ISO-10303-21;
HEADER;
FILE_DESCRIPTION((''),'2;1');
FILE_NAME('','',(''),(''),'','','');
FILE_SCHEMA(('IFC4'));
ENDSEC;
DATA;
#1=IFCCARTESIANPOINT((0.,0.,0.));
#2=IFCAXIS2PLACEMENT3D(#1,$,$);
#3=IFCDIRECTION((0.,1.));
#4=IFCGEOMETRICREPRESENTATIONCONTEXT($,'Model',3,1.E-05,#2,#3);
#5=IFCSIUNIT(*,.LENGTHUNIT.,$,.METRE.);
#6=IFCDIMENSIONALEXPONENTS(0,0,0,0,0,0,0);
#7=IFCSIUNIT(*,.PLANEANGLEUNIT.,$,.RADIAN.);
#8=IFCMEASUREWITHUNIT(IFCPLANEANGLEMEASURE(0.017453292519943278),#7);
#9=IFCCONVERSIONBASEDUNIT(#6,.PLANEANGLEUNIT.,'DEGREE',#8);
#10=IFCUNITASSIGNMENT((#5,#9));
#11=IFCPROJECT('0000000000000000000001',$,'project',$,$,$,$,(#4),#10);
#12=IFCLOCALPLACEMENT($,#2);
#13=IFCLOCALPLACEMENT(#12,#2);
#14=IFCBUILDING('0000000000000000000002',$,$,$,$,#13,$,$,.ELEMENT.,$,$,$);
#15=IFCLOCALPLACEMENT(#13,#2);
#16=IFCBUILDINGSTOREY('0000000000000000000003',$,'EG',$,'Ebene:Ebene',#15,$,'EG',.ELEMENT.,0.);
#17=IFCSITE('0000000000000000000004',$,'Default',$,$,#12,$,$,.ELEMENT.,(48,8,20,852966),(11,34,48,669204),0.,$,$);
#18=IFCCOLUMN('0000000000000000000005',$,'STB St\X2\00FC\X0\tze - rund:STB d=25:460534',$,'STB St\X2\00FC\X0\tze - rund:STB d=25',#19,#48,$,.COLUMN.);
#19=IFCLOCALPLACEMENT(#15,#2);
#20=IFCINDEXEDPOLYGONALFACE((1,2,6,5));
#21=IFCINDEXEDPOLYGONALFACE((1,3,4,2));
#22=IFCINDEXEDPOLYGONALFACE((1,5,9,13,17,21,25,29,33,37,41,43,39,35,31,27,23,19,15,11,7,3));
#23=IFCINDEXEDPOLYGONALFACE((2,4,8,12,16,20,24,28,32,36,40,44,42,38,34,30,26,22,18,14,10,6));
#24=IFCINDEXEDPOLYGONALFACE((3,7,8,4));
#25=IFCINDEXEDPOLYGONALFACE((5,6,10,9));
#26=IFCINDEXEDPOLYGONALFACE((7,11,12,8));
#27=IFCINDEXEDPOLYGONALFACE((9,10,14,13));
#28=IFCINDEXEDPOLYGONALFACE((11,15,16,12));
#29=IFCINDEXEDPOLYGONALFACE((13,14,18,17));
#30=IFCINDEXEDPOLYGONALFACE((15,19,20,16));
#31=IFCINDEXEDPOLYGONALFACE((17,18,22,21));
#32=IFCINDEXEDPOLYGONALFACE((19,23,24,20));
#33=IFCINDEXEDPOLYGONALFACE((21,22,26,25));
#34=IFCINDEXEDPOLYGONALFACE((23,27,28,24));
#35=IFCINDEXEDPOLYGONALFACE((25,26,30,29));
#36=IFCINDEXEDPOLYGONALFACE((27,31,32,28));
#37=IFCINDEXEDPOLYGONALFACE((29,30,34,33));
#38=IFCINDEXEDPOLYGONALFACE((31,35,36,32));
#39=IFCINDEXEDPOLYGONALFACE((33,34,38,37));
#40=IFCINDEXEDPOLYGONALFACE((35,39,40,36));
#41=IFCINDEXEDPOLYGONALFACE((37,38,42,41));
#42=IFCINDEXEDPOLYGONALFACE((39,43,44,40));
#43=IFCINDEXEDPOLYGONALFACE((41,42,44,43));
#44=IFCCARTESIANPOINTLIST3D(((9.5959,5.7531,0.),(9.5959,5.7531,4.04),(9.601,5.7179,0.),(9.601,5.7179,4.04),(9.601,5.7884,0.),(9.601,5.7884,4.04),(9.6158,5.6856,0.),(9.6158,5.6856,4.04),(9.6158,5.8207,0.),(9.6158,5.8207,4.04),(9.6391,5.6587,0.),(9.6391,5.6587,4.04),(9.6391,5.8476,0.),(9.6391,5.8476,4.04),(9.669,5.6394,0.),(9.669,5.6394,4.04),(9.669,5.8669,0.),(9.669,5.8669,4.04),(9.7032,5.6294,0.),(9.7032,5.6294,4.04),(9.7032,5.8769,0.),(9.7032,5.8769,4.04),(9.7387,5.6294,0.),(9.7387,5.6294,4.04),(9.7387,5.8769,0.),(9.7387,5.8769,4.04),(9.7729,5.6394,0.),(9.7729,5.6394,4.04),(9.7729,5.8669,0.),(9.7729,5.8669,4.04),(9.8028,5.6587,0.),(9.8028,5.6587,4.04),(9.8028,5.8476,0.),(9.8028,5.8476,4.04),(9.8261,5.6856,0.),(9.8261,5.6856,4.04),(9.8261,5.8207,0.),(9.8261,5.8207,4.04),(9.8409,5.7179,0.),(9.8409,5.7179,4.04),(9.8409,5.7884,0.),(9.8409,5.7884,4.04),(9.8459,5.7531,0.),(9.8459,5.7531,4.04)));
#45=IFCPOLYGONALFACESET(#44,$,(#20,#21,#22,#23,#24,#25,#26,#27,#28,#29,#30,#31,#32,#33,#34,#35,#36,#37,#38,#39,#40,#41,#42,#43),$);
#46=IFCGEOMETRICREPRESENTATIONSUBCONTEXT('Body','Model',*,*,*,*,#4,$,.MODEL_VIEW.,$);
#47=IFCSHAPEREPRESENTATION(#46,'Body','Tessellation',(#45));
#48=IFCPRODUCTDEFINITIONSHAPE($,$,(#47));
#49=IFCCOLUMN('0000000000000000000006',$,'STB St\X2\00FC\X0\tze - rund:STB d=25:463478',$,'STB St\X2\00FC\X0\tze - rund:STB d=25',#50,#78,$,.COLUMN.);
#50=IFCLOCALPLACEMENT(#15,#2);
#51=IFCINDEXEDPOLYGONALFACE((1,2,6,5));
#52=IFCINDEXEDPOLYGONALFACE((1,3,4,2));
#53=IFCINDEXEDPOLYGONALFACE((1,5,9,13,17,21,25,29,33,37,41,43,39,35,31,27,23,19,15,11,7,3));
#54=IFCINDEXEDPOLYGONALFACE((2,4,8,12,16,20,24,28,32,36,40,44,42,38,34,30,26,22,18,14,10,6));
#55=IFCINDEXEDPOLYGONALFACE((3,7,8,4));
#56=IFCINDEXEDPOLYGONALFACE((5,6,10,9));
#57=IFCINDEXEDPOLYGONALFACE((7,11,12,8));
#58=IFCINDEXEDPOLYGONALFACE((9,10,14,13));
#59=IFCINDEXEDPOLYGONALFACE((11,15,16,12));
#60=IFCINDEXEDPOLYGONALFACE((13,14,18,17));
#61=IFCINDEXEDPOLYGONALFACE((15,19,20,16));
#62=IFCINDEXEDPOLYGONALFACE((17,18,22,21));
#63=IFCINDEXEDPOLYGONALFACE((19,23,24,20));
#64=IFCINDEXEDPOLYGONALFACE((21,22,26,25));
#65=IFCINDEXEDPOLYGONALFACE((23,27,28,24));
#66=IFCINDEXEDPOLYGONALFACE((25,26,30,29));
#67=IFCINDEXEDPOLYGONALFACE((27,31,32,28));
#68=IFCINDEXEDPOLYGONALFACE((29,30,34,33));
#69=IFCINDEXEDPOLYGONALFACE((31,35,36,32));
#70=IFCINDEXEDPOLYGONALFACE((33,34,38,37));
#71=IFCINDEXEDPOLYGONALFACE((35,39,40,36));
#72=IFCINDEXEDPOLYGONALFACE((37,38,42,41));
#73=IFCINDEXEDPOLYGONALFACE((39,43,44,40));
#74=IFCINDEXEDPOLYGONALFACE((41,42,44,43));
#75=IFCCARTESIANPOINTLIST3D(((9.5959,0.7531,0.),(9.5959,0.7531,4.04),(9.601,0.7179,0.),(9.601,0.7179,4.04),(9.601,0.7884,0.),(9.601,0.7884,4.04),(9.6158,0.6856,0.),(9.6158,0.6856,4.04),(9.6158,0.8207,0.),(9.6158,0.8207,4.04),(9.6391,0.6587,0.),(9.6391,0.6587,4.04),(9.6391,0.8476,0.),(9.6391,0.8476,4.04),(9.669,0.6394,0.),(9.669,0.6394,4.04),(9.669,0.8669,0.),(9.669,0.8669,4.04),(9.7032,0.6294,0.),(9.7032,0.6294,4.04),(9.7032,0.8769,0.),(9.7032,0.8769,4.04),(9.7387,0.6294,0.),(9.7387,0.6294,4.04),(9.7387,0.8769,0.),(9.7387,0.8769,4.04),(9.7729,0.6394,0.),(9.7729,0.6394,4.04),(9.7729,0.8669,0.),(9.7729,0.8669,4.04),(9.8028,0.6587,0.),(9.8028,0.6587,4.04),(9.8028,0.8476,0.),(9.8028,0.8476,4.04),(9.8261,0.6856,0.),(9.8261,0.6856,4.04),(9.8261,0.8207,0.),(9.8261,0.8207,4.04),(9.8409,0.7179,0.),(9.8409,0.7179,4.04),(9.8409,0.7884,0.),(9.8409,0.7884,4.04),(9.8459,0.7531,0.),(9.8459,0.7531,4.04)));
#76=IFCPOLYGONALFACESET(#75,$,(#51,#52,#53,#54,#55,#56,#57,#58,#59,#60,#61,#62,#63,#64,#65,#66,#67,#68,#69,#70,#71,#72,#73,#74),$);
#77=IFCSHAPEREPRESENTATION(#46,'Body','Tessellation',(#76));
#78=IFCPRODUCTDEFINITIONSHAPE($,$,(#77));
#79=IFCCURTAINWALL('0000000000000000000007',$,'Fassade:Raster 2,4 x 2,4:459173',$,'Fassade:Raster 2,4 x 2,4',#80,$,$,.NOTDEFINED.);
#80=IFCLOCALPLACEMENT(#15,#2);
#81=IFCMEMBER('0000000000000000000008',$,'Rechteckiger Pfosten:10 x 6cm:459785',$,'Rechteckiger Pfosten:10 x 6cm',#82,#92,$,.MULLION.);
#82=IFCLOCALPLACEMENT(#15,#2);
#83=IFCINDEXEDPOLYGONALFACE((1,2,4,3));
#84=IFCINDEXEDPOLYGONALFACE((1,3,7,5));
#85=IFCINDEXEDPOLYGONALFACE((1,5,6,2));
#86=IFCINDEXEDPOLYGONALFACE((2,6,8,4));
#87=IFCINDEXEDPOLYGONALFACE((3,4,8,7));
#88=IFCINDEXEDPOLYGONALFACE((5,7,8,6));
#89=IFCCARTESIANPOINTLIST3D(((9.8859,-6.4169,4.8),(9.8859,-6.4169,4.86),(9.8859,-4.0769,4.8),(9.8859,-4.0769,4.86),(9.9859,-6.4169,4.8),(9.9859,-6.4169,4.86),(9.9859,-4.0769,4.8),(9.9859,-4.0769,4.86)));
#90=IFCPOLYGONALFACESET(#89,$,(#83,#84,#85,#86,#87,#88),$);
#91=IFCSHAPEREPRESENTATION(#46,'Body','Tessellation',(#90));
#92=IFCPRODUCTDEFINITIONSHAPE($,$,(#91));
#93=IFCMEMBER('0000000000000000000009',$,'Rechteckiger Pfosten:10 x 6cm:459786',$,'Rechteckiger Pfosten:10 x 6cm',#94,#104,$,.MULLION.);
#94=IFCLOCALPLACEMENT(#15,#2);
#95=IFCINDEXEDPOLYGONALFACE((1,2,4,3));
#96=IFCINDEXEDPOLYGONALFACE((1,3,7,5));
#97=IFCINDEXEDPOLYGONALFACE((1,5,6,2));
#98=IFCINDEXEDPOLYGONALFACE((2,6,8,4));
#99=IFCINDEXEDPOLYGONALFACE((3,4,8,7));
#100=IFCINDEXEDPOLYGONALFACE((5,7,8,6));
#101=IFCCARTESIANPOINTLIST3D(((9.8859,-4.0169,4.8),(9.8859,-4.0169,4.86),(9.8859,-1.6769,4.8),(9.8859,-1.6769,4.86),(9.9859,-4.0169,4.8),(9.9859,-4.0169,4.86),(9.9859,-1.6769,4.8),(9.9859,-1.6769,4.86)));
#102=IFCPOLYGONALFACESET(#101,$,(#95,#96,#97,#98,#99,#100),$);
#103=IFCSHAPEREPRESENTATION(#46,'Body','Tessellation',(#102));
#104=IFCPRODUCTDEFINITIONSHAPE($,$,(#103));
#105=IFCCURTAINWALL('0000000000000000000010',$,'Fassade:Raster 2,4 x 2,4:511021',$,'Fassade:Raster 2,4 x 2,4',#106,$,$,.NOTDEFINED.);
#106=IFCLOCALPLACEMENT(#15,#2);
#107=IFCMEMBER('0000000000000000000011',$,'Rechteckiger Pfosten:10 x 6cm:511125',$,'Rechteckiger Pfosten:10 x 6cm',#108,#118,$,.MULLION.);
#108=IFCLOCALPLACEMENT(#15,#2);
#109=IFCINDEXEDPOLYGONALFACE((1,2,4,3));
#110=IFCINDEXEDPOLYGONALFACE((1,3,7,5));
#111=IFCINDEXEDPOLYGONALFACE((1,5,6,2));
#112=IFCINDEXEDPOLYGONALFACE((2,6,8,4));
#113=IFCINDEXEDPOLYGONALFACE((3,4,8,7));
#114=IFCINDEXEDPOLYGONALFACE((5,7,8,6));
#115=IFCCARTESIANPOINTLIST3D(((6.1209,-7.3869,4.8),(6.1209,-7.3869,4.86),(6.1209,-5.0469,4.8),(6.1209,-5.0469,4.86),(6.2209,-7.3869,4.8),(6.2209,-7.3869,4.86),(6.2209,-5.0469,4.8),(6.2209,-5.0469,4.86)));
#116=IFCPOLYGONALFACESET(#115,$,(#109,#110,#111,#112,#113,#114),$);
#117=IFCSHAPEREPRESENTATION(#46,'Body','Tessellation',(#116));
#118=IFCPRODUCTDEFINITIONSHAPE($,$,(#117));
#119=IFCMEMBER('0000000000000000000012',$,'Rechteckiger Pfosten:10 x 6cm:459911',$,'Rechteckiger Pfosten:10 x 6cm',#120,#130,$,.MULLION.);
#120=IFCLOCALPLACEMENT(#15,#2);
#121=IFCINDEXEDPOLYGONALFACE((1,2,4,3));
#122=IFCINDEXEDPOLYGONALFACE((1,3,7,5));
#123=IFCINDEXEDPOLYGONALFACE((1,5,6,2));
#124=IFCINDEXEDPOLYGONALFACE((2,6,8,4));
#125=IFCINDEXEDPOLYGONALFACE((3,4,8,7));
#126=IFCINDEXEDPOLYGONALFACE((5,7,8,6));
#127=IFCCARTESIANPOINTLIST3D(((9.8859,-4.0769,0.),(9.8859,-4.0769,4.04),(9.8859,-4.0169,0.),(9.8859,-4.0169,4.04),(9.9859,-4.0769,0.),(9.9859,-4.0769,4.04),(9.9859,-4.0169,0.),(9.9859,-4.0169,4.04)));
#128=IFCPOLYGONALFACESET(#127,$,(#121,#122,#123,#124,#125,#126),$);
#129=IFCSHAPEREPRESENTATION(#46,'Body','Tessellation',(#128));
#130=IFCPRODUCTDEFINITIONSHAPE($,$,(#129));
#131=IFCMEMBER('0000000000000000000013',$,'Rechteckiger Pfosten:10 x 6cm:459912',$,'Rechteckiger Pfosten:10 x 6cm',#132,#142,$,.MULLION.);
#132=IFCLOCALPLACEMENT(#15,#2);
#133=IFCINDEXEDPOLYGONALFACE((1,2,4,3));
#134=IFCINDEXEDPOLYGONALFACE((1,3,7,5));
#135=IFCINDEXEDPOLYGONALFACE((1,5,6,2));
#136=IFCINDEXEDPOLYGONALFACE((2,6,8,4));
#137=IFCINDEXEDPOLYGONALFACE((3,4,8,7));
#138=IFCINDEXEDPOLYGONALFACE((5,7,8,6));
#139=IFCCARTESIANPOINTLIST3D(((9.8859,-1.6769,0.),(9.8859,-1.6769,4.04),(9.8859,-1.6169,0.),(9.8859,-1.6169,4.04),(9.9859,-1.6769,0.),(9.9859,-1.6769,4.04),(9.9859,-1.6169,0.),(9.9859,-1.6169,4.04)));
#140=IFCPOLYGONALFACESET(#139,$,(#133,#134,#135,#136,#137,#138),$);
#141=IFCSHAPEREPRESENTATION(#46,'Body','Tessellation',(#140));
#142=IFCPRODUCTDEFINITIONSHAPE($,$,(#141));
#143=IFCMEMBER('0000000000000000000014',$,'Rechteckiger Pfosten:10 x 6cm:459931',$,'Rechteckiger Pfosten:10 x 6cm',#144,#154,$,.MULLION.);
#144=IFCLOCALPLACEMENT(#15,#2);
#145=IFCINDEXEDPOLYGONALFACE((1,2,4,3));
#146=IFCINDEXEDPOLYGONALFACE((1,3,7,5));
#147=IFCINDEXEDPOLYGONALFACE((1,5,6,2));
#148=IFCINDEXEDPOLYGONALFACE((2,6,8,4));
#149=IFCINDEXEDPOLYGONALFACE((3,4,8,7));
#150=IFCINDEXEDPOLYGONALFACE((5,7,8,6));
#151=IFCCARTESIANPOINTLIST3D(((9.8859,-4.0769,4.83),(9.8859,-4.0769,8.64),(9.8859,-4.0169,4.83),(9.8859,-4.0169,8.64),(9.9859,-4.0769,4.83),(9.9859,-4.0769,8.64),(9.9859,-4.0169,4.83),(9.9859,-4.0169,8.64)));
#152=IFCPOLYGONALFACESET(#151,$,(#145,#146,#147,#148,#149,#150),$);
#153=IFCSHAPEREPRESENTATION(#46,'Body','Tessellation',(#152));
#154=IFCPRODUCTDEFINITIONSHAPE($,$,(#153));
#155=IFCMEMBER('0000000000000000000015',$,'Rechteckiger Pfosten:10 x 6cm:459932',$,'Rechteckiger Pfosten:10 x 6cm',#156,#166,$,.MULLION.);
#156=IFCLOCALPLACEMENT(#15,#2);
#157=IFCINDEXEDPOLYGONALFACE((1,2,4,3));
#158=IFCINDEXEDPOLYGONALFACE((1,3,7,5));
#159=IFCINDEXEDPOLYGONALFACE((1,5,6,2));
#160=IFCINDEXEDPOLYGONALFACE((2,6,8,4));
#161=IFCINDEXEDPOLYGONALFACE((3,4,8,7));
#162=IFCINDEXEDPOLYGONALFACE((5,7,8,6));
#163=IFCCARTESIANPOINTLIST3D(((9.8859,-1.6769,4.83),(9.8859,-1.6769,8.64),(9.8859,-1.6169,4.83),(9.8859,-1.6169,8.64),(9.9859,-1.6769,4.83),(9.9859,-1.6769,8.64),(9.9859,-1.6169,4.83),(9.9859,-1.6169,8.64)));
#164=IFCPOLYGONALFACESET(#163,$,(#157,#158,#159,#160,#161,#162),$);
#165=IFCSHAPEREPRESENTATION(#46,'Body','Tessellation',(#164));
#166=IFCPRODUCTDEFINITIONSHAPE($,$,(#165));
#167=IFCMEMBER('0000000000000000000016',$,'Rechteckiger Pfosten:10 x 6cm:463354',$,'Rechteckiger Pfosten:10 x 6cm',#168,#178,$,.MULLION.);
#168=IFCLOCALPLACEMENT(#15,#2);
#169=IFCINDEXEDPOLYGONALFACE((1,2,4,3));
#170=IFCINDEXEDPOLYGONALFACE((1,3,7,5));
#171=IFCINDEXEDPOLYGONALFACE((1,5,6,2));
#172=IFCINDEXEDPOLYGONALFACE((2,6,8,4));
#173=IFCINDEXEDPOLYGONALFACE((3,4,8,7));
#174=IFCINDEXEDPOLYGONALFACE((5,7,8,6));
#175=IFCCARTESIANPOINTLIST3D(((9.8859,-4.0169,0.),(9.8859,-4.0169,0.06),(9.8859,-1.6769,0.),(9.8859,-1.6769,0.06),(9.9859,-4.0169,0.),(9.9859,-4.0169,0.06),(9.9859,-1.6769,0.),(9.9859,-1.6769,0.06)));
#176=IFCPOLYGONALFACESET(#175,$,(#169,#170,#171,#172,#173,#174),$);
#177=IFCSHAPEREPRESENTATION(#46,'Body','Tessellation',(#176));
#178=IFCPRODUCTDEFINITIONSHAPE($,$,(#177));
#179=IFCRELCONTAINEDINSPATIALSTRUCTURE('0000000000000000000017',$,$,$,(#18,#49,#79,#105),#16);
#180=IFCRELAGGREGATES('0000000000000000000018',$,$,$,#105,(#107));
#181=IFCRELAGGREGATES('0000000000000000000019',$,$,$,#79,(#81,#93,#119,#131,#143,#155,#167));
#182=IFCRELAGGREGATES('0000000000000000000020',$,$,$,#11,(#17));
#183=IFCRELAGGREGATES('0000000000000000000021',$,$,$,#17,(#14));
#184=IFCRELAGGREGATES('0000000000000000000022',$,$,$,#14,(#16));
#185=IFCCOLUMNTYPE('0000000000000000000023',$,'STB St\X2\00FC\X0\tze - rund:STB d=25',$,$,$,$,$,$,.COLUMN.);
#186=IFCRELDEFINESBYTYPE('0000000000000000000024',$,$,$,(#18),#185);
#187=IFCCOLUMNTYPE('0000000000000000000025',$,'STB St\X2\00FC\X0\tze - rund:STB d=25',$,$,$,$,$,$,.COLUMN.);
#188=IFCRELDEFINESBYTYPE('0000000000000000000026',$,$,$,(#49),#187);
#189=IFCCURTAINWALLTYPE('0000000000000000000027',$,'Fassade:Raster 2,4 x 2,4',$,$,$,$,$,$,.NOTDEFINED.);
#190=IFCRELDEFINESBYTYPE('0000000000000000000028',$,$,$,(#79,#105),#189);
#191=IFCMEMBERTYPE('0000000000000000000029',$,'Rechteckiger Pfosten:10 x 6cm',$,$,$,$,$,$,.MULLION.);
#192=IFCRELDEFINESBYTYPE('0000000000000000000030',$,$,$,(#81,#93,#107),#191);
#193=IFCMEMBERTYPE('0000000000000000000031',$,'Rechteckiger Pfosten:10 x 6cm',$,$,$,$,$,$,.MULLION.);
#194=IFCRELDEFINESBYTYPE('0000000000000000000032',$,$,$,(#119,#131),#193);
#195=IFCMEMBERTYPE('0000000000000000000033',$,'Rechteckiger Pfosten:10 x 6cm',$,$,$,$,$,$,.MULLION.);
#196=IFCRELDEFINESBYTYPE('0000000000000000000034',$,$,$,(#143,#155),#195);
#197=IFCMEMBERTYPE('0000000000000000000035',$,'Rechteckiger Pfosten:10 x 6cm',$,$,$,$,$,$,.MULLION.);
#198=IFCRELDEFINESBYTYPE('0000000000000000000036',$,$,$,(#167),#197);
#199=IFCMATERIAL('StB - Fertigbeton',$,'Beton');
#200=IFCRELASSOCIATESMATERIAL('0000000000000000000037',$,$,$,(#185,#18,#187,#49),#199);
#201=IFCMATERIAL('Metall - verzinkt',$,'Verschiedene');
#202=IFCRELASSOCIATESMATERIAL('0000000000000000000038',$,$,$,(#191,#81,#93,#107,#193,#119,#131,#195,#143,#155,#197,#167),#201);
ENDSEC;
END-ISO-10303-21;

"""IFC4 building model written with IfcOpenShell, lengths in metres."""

from ifc_helpers import new_model, entity, si_unit, converted_unit, direction, frame, origin, place, context, subcontext, project, spatial, arc, indexed_curve, outline, extrude, source, transform, mapped, material, type_object, type_shapes, element, aggregate, save


model = new_model("IFC4")

# Units and contexts
model_context = context("Model", 3, precision=1e-05, world=origin(), true_north=direction((0.0, 1.0)))
body_context = subcontext(model_context, "Body", "Model", "MODEL_VIEW")
ifc_project = project(units=[si_unit("LENGTHUNIT", "METRE"), converted_unit("PLANEANGLEUNIT", "DEGREE", entity("IfcPlaneAngleMeasure", 0.017453292519943278), si_unit("PLANEANGLEUNIT", "RADIAN"), dimensions=[0, 0, 0, 0, 0, 0, 0])], contexts=[model_context])

# Site, building, storey
site_placement = place(None, origin())
site = spatial("IfcSite", under=ifc_project, at=site_placement, Name="Default", CompositionType="ELEMENT", RefLatitude=(48, 8, 20, 852966), RefLongitude=(11, 34, 48, 669204), RefElevation=0.0)
building_placement = place(site_placement, origin())
building = spatial("IfcBuilding", under=site, at=building_placement, CompositionType="ELEMENT")
storey_placement = place(building_placement, origin())
storey = spatial("IfcBuildingStorey", under=building, at=storey_placement, Name="EG", ObjectType="Ebene:Ebene", LongName="EG", CompositionType="ELEMENT", Elevation=0.0)

# Columns
ifc_material_1 = material(Name="StB - Fertigbeton", Category="Beton")
column_type_1 = type_object("IfcColumnType", Name="STB Stütze - rund:STB d=25", PredefinedType="COLUMN", material=ifc_material_1)
shared_shape_1 = source(origin(), body_context, "Body", "SweptSolid", [
    extrude(outline(indexed_curve([(-0.125, 0.0), (0.0, -0.125), (0.125, 0.0), (0.0, 0.125)], segments=[arc(1, 2, 3), arc(3, 4, 1)], self_intersect=False)), frame((9.7209, 5.7531, 0.0)), (0.0, 0.0, 1.0), 4.04),
])
type_shapes(column_type_1, [shared_shape_1])
column_1_placement = place(storey_placement, origin())
element("IfcColumn", 1, at=column_1_placement, inside=storey, type_object=column_type_1, material=ifc_material_1, Name="STB Stütze - rund:STB d=25:460534", ObjectType="STB Stütze - rund:STB d=25", PredefinedType="COLUMN", context=body_context, shape_type="MappedRepresentation", body=[
    mapped(shared_shape_1, transform((0.0, 0.0, 0.0), scale=1.0)),
])
column_type_2 = type_object("IfcColumnType", Name="STB Stütze - rund:STB d=25", PredefinedType="COLUMN", material=ifc_material_1)
shared_shape_2 = source(origin(), body_context, "Body", "SweptSolid", [
    extrude(outline(indexed_curve([(-0.125, 0.0), (0.0, -0.125), (0.125, 0.0), (0.0, 0.125)], segments=[arc(1, 2, 3), arc(3, 4, 1)], self_intersect=False)), frame((9.7209, 0.7531, 0.0)), (0.0, 0.0, 1.0), 4.04),
])
type_shapes(column_type_2, [shared_shape_2])
column_2_placement = place(storey_placement, origin())
element("IfcColumn", 2, at=column_2_placement, inside=storey, type_object=column_type_2, material=ifc_material_1, Name="STB Stütze - rund:STB d=25:463478", ObjectType="STB Stütze - rund:STB d=25", PredefinedType="COLUMN", context=body_context, shape_type="MappedRepresentation", body=[
    mapped(shared_shape_2, transform((0.0, 0.0, 0.0), scale=1.0)),
])

# Curtain wall, members
curtain_wall_type = type_object("IfcCurtainWallType", Name="Fassade:Raster 2,4 x 2,4", PredefinedType="NOTDEFINED")
curtain_wall_1_placement = place(storey_placement, origin())
curtain_wall_1 = element("IfcCurtainWall", 3, at=curtain_wall_1_placement, inside=storey, type_object=curtain_wall_type, Name="Fassade:Raster 2,4 x 2,4:459173", ObjectType="Fassade:Raster 2,4 x 2,4", PredefinedType="NOTDEFINED")
ifc_material_2 = material(Name="Metall - verzinkt", Category="Verschiedene")
member_type_1 = type_object("IfcMemberType", Name="Rechteckiger Pfosten:10 x 6cm", PredefinedType="MULLION", material=ifc_material_2)
shared_shape_3 = source(origin(), body_context, "Body", "SweptSolid", [
    extrude(outline(indexed_curve([(-0.03, -0.05), (0.03, -0.05), (0.03, 0.05), (-0.03, 0.05), (-0.03, -0.05)], self_intersect=False)), frame((0.0, 0.0, -2.34), z_axis=(0.0, 0.0, 1.0), x_axis=(-1.0, 0.0, 0.0)), (0.0, 0.0, 1.0), 2.34),
])
type_shapes(member_type_1, [shared_shape_3])
member_1_placement = place(curtain_wall_1_placement, frame((9.9359, -4.0769, 4.83), z_axis=(0.0, 1.0, 0.0), x_axis=(0.0, 0.0, 1.0)))
member_1 = element("IfcMember", 4, at=member_1_placement, type_object=member_type_1, material=ifc_material_2, Name="Rechteckiger Pfosten:10 x 6cm:459785", ObjectType="Rechteckiger Pfosten:10 x 6cm", PredefinedType="MULLION", context=body_context, shape_type="MappedRepresentation", body=[
    mapped(shared_shape_3, transform((0.0, 0.0, 0.0), scale=1.0)),
])
member_2_placement = place(curtain_wall_1_placement, frame((9.9359, -1.6769, 4.83), z_axis=(0.0, 1.0, 0.0), x_axis=(0.0, 0.0, 1.0)))
member_2 = element("IfcMember", 5, at=member_2_placement, type_object=member_type_1, material=ifc_material_2, Name="Rechteckiger Pfosten:10 x 6cm:459786", ObjectType="Rechteckiger Pfosten:10 x 6cm", PredefinedType="MULLION", context=body_context, shape_type="MappedRepresentation", body=[
    mapped(shared_shape_3, transform((0.0, 0.0, 0.0), scale=1.0)),
])

# Curtain wall, member
curtain_wall_2_placement = place(storey_placement, origin())
curtain_wall_2 = element("IfcCurtainWall", 6, at=curtain_wall_2_placement, inside=storey, type_object=curtain_wall_type, Name="Fassade:Raster 2,4 x 2,4:511021", ObjectType="Fassade:Raster 2,4 x 2,4", PredefinedType="NOTDEFINED")
member_3_placement = place(curtain_wall_2_placement, frame((6.1709, -5.0469, 4.83), z_axis=(0.0, 1.0, 0.0), x_axis=(0.0, 0.0, 1.0)))
member_3 = element("IfcMember", 7, at=member_3_placement, type_object=member_type_1, material=ifc_material_2, Name="Rechteckiger Pfosten:10 x 6cm:511125", ObjectType="Rechteckiger Pfosten:10 x 6cm", PredefinedType="MULLION", context=body_context, shape_type="MappedRepresentation", body=[
    mapped(shared_shape_3, transform((0.0, 0.0, 0.0), scale=1.0)),
])

# Members
member_type_2 = type_object("IfcMemberType", Name="Rechteckiger Pfosten:10 x 6cm", PredefinedType="MULLION", material=ifc_material_2)
shared_shape_4 = source(origin(), body_context, "Body", "SweptSolid", [
    extrude(outline(indexed_curve([(-0.03, -0.05), (0.03, -0.05), (0.03, 0.05), (-0.03, 0.05), (-0.03, -0.05)], self_intersect=False)), frame((0.0, 0.0, -4.04), z_axis=(0.0, 0.0, 1.0), x_axis=(-1.0, 0.0, 0.0)), (0.0, 0.0, 1.0), 4.04),
])
type_shapes(member_type_2, [shared_shape_4])
member_4_placement = place(curtain_wall_1_placement, frame((9.9359, -4.0469, 0.0), z_axis=(0.0, 0.0, -1.0), x_axis=(0.0, 1.0, 0.0)))
member_4 = element("IfcMember", 8, at=member_4_placement, type_object=member_type_2, material=ifc_material_2, Name="Rechteckiger Pfosten:10 x 6cm:459911", ObjectType="Rechteckiger Pfosten:10 x 6cm", PredefinedType="MULLION", context=body_context, shape_type="MappedRepresentation", body=[
    mapped(shared_shape_4, transform((0.0, 0.0, 0.0), scale=1.0)),
])
member_5_placement = place(curtain_wall_1_placement, frame((9.9359, -1.6469, 0.0), z_axis=(0.0, 0.0, -1.0), x_axis=(0.0, 1.0, 0.0)))
member_5 = element("IfcMember", 9, at=member_5_placement, type_object=member_type_2, material=ifc_material_2, Name="Rechteckiger Pfosten:10 x 6cm:459912", ObjectType="Rechteckiger Pfosten:10 x 6cm", PredefinedType="MULLION", context=body_context, shape_type="MappedRepresentation", body=[
    mapped(shared_shape_4, transform((0.0, 0.0, 0.0), scale=1.0)),
])
member_type_3 = type_object("IfcMemberType", Name="Rechteckiger Pfosten:10 x 6cm", PredefinedType="MULLION", material=ifc_material_2)
shared_shape_5 = source(origin(), body_context, "Body", "SweptSolid", [
    extrude(outline(indexed_curve([(-0.03, -0.05), (0.03, -0.05), (0.03, 0.05), (-0.03, 0.05), (-0.03, -0.05)], self_intersect=False)), frame((0.0, 0.0, -3.81), z_axis=(0.0, 0.0, 1.0), x_axis=(-1.0, 0.0, 0.0)), (0.0, 0.0, 1.0), 3.81),
])
type_shapes(member_type_3, [shared_shape_5])
member_6_placement = place(curtain_wall_1_placement, frame((9.9359, -4.0469, 4.83), z_axis=(0.0, 0.0, -1.0), x_axis=(0.0, 1.0, 0.0)))
member_6 = element("IfcMember", 10, at=member_6_placement, type_object=member_type_3, material=ifc_material_2, Name="Rechteckiger Pfosten:10 x 6cm:459931", ObjectType="Rechteckiger Pfosten:10 x 6cm", PredefinedType="MULLION", context=body_context, shape_type="MappedRepresentation", body=[
    mapped(shared_shape_5, transform((0.0, 0.0, 0.0), scale=1.0)),
])
member_7_placement = place(curtain_wall_1_placement, frame((9.9359, -1.6469, 4.83), z_axis=(0.0, 0.0, -1.0), x_axis=(0.0, 1.0, 0.0)))
member_7 = element("IfcMember", 11, at=member_7_placement, type_object=member_type_3, material=ifc_material_2, Name="Rechteckiger Pfosten:10 x 6cm:459932", ObjectType="Rechteckiger Pfosten:10 x 6cm", PredefinedType="MULLION", context=body_context, shape_type="MappedRepresentation", body=[
    mapped(shared_shape_5, transform((0.0, 0.0, 0.0), scale=1.0)),
])
member_type_4 = type_object("IfcMemberType", Name="Rechteckiger Pfosten:10 x 6cm", PredefinedType="MULLION", material=ifc_material_2)
shared_shape_6 = source(origin(), body_context, "Body", "SweptSolid", [
    extrude(outline(indexed_curve([(-0.03, -0.05), (0.03, -0.05), (0.03, 0.05), (-0.03, 0.05), (-0.03, -0.05)], self_intersect=False)), frame((-0.03, 0.0, -2.34), z_axis=(0.0, 0.0, 1.0), x_axis=(-1.0, 0.0, 0.0)), (0.0, 0.0, 1.0), 2.34),
])
type_shapes(member_type_4, [shared_shape_6])
member_8_placement = place(curtain_wall_1_placement, frame((9.9359, -4.0169, 0.0), z_axis=(0.0, -1.0, 0.0), x_axis=(0.0, 0.0, -1.0)))
member_8 = element("IfcMember", 12, at=member_8_placement, type_object=member_type_4, material=ifc_material_2, Name="Rechteckiger Pfosten:10 x 6cm:463354", ObjectType="Rechteckiger Pfosten:10 x 6cm", PredefinedType="MULLION", context=body_context, shape_type="MappedRepresentation", body=[
    mapped(shared_shape_6, transform((0.0, 0.0, 0.0), scale=1.0)),
])
aggregate(curtain_wall_2, [member_3])

aggregate(curtain_wall_1, [member_1, member_2, member_4, member_5, member_6, member_7, member_8])

save(model, "model.ifc")
